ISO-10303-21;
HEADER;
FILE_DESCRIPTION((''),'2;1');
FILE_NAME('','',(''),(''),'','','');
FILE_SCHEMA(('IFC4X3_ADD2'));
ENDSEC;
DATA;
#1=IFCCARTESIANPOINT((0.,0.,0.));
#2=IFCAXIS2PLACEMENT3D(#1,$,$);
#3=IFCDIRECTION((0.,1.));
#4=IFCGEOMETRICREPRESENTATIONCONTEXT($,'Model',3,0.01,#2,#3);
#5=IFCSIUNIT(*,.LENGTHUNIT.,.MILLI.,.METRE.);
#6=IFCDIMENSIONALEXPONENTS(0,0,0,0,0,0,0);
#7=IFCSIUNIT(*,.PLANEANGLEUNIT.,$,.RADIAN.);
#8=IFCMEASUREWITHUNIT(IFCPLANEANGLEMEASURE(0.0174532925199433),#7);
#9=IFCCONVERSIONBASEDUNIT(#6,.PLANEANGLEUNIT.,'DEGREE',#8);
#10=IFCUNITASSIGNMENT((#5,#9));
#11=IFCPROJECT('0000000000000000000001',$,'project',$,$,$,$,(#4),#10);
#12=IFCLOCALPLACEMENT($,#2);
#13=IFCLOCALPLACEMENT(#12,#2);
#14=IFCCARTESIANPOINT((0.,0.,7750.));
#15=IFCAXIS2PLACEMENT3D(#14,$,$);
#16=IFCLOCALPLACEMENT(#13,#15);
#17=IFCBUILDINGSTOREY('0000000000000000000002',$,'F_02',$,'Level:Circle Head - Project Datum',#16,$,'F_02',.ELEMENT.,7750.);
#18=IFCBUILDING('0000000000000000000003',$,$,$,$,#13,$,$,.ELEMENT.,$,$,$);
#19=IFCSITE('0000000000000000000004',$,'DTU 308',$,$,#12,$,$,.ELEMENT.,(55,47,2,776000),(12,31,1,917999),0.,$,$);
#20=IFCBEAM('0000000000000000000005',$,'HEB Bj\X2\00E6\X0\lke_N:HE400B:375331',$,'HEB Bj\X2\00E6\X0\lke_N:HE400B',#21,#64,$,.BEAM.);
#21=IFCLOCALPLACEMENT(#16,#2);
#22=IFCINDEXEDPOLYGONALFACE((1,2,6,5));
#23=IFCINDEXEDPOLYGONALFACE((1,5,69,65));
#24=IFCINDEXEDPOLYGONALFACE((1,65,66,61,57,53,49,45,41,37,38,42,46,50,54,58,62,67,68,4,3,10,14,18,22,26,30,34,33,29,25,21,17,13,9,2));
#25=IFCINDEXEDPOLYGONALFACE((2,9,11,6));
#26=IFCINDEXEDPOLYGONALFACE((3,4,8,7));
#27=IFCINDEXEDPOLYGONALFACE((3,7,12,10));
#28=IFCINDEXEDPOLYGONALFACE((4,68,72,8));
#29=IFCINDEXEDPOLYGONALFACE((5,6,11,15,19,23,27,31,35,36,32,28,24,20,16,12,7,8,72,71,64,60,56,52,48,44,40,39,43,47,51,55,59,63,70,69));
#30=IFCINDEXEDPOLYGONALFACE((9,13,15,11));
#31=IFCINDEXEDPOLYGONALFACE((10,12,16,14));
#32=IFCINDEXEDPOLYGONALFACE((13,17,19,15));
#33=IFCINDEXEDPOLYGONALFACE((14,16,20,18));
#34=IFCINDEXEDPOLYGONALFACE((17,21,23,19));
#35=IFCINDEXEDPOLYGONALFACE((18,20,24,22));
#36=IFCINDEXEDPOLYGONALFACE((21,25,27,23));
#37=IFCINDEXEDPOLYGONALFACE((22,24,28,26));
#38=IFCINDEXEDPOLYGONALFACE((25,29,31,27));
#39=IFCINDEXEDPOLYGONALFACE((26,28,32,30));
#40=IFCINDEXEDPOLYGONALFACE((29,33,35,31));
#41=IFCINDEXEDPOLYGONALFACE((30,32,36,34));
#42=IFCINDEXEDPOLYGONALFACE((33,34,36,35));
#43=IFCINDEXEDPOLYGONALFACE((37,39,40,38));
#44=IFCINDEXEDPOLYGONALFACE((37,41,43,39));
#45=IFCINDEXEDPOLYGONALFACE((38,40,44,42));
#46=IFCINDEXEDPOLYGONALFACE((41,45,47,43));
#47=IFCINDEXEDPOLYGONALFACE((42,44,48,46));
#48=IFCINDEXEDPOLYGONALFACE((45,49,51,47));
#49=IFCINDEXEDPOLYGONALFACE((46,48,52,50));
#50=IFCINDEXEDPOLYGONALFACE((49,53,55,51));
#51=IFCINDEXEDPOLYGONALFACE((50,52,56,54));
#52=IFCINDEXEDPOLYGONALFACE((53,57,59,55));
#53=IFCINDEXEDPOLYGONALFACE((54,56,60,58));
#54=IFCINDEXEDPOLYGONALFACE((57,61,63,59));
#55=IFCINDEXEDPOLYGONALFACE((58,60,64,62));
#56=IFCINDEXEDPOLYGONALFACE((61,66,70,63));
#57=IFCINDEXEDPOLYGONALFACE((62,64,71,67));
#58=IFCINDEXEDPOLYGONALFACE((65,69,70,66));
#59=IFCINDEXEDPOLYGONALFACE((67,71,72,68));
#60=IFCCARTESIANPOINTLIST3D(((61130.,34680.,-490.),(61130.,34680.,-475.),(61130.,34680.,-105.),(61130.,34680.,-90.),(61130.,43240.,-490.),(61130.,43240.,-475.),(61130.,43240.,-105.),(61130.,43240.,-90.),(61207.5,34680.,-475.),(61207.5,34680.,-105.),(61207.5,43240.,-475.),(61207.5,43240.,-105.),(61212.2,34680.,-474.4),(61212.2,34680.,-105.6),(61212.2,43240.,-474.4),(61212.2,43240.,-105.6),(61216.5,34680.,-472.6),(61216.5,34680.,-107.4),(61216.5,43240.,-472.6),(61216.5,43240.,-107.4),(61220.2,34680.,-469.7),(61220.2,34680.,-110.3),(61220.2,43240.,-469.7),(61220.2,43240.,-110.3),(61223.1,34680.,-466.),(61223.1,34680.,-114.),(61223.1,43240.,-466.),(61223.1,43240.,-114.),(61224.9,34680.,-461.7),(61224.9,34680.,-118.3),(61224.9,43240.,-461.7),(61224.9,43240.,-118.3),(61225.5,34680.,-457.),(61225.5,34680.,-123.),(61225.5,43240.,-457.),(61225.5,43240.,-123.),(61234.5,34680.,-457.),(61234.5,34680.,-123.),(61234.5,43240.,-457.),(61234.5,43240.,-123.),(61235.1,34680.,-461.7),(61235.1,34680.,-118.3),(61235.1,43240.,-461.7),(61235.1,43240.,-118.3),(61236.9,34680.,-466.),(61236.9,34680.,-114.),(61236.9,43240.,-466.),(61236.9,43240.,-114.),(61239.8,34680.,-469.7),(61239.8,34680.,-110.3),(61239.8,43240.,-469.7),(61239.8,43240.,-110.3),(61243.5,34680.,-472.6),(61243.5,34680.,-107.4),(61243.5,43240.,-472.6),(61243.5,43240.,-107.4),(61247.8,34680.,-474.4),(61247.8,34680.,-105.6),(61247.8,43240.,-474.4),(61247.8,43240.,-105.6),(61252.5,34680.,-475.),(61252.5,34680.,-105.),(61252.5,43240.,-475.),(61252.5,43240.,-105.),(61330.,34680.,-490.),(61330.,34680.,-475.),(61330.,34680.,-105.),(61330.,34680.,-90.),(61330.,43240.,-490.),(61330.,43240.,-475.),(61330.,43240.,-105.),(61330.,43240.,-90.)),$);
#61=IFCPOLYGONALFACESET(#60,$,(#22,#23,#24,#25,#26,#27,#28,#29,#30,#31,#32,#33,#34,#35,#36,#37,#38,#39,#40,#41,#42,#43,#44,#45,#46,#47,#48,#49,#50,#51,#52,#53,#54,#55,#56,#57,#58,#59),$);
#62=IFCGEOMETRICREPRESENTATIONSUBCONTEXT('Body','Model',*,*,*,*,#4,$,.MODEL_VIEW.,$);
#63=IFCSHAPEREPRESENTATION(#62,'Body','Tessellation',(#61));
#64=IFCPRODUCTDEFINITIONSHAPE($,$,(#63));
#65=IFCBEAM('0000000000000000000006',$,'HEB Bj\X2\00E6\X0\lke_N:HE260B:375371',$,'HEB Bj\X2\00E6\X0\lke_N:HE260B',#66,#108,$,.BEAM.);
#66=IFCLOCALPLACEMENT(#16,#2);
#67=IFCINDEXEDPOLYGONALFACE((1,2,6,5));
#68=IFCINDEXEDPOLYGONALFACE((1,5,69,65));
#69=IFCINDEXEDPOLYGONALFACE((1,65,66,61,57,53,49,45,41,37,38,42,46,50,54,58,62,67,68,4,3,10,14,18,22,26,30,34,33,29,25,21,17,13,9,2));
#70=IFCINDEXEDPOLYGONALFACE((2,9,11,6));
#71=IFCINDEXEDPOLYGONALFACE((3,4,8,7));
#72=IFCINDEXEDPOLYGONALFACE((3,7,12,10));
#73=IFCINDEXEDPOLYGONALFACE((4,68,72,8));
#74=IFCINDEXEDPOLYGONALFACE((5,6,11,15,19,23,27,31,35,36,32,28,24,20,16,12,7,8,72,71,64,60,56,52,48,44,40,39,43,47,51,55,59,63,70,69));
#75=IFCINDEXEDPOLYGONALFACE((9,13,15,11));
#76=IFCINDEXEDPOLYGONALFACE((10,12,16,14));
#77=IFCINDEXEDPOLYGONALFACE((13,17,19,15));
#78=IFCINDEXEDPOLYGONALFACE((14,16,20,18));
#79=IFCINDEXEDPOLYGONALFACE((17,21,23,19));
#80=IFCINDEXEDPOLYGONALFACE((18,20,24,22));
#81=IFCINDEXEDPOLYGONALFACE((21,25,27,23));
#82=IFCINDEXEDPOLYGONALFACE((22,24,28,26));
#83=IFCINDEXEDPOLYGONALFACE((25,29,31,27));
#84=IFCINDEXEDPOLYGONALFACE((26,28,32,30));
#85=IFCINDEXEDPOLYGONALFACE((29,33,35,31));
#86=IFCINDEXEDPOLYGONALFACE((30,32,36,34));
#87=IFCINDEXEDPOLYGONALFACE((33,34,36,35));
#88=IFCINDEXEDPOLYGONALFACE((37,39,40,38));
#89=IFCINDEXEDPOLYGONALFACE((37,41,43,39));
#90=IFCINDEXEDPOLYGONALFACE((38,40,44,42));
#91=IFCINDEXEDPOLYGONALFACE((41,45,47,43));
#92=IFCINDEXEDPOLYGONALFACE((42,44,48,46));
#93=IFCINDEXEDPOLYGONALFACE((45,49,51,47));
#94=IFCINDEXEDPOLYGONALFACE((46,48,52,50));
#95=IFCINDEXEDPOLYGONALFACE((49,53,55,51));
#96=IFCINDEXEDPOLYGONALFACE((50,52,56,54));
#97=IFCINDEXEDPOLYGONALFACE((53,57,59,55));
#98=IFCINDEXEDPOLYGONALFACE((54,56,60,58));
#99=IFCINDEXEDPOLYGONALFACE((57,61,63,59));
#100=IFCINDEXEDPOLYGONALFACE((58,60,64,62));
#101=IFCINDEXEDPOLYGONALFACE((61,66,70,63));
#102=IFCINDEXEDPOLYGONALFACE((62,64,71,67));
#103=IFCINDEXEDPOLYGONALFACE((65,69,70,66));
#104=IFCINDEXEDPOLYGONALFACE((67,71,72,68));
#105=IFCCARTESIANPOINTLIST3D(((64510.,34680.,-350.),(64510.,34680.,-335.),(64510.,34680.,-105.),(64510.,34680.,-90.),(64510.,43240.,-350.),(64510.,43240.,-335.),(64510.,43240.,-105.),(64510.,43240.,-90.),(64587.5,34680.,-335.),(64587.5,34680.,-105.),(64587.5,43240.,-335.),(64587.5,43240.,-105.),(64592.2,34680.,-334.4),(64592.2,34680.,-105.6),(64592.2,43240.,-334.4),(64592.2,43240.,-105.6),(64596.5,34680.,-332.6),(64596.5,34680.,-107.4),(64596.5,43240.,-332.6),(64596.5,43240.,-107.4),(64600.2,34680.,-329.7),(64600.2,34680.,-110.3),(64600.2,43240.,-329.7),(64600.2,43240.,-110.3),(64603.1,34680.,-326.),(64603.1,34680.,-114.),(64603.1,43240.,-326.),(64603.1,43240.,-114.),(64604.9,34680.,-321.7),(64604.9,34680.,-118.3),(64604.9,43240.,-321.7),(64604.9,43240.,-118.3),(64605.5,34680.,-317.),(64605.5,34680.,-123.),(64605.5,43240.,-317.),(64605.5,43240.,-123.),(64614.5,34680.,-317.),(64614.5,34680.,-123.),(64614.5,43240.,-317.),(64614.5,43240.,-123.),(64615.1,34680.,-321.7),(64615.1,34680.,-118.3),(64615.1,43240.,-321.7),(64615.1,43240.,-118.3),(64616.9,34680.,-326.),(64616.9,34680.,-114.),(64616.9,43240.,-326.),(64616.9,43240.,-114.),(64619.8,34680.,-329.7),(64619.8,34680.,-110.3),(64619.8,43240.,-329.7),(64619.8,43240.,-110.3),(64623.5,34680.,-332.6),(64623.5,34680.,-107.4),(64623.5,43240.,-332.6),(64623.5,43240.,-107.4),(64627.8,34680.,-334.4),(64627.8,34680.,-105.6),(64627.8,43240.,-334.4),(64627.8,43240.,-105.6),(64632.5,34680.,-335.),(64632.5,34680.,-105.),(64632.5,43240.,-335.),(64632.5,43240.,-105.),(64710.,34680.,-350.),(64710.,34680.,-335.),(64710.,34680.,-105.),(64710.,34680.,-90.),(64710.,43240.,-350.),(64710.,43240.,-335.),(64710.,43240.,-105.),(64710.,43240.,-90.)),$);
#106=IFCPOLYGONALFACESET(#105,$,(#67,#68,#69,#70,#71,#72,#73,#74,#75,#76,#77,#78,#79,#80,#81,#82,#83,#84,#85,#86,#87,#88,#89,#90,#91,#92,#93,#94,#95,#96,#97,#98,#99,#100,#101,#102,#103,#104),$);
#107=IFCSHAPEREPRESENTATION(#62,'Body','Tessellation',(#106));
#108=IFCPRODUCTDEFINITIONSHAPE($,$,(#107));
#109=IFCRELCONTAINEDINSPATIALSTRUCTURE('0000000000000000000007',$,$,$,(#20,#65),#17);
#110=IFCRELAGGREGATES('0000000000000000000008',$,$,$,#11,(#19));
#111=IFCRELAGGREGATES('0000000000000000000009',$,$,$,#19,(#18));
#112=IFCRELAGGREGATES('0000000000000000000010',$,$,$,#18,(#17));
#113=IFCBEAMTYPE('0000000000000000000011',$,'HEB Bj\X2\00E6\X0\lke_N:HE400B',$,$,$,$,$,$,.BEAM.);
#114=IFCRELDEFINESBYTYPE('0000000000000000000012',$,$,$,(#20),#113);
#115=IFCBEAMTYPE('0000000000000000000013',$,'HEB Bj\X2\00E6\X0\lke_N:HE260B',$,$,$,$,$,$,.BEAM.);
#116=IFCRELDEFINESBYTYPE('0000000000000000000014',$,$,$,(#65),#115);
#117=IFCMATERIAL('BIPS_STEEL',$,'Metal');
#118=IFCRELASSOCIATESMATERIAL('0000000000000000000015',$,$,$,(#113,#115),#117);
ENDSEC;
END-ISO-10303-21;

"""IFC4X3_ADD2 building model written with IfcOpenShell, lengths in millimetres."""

from ifc_helpers import new_model, entity, si_unit, converted_unit, direction, frame, frame_2d, origin, place, context, subcontext, project, spatial, polyline, circle_curve, parameter, trimmed, segment, composite_curve, i_section, outline, extrude, source, transform, mapped, material, material_profile, profile_set, type_object, element, save


model = new_model("IFC4X3_ADD2")

# Units and contexts
model_context = context("Model", 3, precision=0.01, world=origin(), true_north=direction((0.0, 1.0)))
body_context = subcontext(model_context, "Body", "Model", "MODEL_VIEW")
ifc_project = project(units=[si_unit("LENGTHUNIT", "METRE", prefix="MILLI"), converted_unit("PLANEANGLEUNIT", "DEGREE", entity("IfcPlaneAngleMeasure", 0.0174532925199433), si_unit("PLANEANGLEUNIT", "RADIAN"), dimensions=[0, 0, 0, 0, 0, 0, 0])], contexts=[model_context])

# Site, building, storey
site_placement = place(None, origin())
site = spatial("IfcSite", under=ifc_project, at=site_placement, Name="DTU 308", CompositionType="ELEMENT", RefLatitude=(55, 47, 2, 776000), RefLongitude=(12, 31, 1, 917999), RefElevation=0.0)
building_placement = place(site_placement, origin())
building = spatial("IfcBuilding", under=site, at=building_placement, CompositionType="ELEMENT")
storey_placement = place(building_placement, frame((0.0, 0.0, 7750.0)))
storey = spatial("IfcBuildingStorey", under=building, at=storey_placement, Name="F_02", ObjectType="Level:Circle Head - Project Datum", LongName="F_02", CompositionType="ELEMENT", Elevation=7750.0)

# Shared definitions
ifc_material = material(Name="BIPS_STEEL", Category="Metal")

# Beams
ifc_material_profile_1 = material_profile(ifc_material, outline(composite_curve([segment(polyline([(-100.0, -185.0), (-100.0, -200.0)]), True, "CONTINUOUS"), segment(polyline([(-100.0, -200.0), (100.0, -200.0)]), True, "CONTINUOUS"), segment(polyline([(100.0, -200.0), (100.0, -185.0)]), True, "CONTINUOUS"), segment(polyline([(100.0, -185.0), (22.5, -185.0)]), True, "CONTINUOUS"), segment(trimmed(circle_curve(frame_2d((22.5, -167.0), x_axis=(1.0, 0.0)), 18.0), [parameter(180.0)], [parameter(270.0)], True, "PARAMETER"), False, "CONTINUOUS"), segment(polyline([(4.5, -167.0), (4.5, 167.0)]), True, "CONTINUOUS"), segment(trimmed(circle_curve(frame_2d((22.5, 167.0), x_axis=(1.0, 0.0)), 18.0), [parameter(90.0)], [parameter(180.0)], True, "PARAMETER"), False, "CONTINUOUS"), segment(polyline([(22.5, 185.0), (100.0, 185.0)]), True, "CONTINUOUS"), segment(polyline([(100.0, 185.0), (100.0, 200.0)]), True, "CONTINUOUS"), segment(polyline([(100.0, 200.0), (-100.0, 200.0)]), True, "CONTINUOUS"), segment(polyline([(-100.0, 200.0), (-100.0, 185.0)]), True, "CONTINUOUS"), segment(polyline([(-100.0, 185.0), (-22.5, 185.0)]), True, "CONTINUOUS"), segment(trimmed(circle_curve(frame_2d((-22.5, 167.0), x_axis=(1.0, 0.0)), 18.0), [parameter(360.0)], [parameter(90.0)], True, "PARAMETER"), False, "CONTINUOUS"), segment(polyline([(-4.5, 167.0), (-4.5, -167.0)]), True, "CONTINUOUS"), segment(trimmed(circle_curve(frame_2d((-22.5, -167.0), x_axis=(1.0, 0.0)), 18.0), [parameter(270.0)], [parameter(360.0)], True, "PARAMETER"), False, "CONTINUOUS"), segment(polyline([(-22.5, -185.0), (-100.0, -185.0)]), True, "CONTINUOUS")], self_intersect=False)), Name="HE400B")
ifc_profile_set_1 = profile_set([ifc_material_profile_1], Name="HE400B")
beam_type_1 = type_object("IfcBeamType", Name="HEB Bjælke_N:HE400B", PredefinedType="BEAM", material=ifc_profile_set_1)
shared_shape_1 = source(origin(), body_context, "Body", "SweptSolid", [
    extrude(outline(composite_curve([segment(polyline([(-100.0, -185.0), (-100.0, -200.0)]), True, "CONTINUOUS"), segment(polyline([(-100.0, -200.0), (100.0, -200.0)]), True, "CONTINUOUS"), segment(polyline([(100.0, -200.0), (100.0, -185.0)]), True, "CONTINUOUS"), segment(polyline([(100.0, -185.0), (22.5, -185.0)]), True, "CONTINUOUS"), segment(trimmed(circle_curve(frame_2d((22.5, -167.0), x_axis=(1.0, 0.0)), 18.0), [parameter(180.0)], [parameter(270.0)], True, "PARAMETER"), False, "CONTINUOUS"), segment(polyline([(4.5, -167.0), (4.5, 167.0)]), True, "CONTINUOUS"), segment(trimmed(circle_curve(frame_2d((22.5, 167.0), x_axis=(1.0, 0.0)), 18.0), [parameter(90.0)], [parameter(180.0)], True, "PARAMETER"), False, "CONTINUOUS"), segment(polyline([(22.5, 185.0), (100.0, 185.0)]), True, "CONTINUOUS"), segment(polyline([(100.0, 185.0), (100.0, 200.0)]), True, "CONTINUOUS"), segment(polyline([(100.0, 200.0), (-100.0, 200.0)]), True, "CONTINUOUS"), segment(polyline([(-100.0, 200.0), (-100.0, 185.0)]), True, "CONTINUOUS"), segment(polyline([(-100.0, 185.0), (-22.5, 185.0)]), True, "CONTINUOUS"), segment(trimmed(circle_curve(frame_2d((-22.5, 167.0), x_axis=(1.0, 0.0)), 18.0), [parameter(360.0)], [parameter(90.0)], True, "PARAMETER"), False, "CONTINUOUS"), segment(polyline([(-4.5, 167.0), (-4.5, -167.0)]), True, "CONTINUOUS"), segment(trimmed(circle_curve(frame_2d((-22.5, -167.0), x_axis=(1.0, 0.0)), 18.0), [parameter(270.0)], [parameter(360.0)], True, "PARAMETER"), False, "CONTINUOUS"), segment(polyline([(-22.5, -185.0), (-100.0, -185.0)]), True, "CONTINUOUS")], self_intersect=False)), frame((-4280.0, 0.0, 0.0), z_axis=(-1.0, 0.0, 0.0), x_axis=(0.0, -1.0, 0.0)), (0.0, 0.0, -1.0), 8560.0),
])
for number, where, z_axis, x_axis, name in (
    (1, (61230.0, 38960.0, -290.0), (0.0, 0.0, 1.0), (0.0, -1.0, 0.0), "HEB Bjælke_N:HE400B:375331"),
):
    element("IfcBeam", number, at=place(storey_placement, frame(where, z_axis=z_axis, x_axis=x_axis)), inside=storey, type_object=beam_type_1, Name=name, ObjectType="HEB Bjælke_N:HE400B", PredefinedType="BEAM", context=body_context, shape_type="MappedRepresentation", body=[
        mapped(shared_shape_1, transform((0.0, 0.0, 0.0), scale=1.0)),
    ])
ifc_material_profile_2 = material_profile(ifc_material, i_section(OverallWidth=200.0, OverallDepth=260.0, WebThickness=9.0, FlangeThickness=15.0, FilletRadius=18.0, at=frame_2d((0.0, 0.0), x_axis=(1.0, 0.0))), Name="HE260B")
ifc_profile_set_2 = profile_set([ifc_material_profile_2], Name="HE260B")
beam_type_2 = type_object("IfcBeamType", Name="HEB Bjælke_N:HE260B", PredefinedType="BEAM", material=ifc_profile_set_2)
shared_shape_2 = source(origin(), body_context, "Body", "SweptSolid", [
    extrude(outline(composite_curve([segment(polyline([(-100.0, -115.0), (-100.0, -130.0)]), True, "CONTINUOUS"), segment(polyline([(-100.0, -130.0), (100.0, -130.0)]), True, "CONTINUOUS"), segment(polyline([(100.0, -130.0), (100.0, -115.0)]), True, "CONTINUOUS"), segment(polyline([(100.0, -115.0), (22.5, -115.0)]), True, "CONTINUOUS"), segment(trimmed(circle_curve(frame_2d((22.5, -97.0), x_axis=(1.0, 0.0)), 18.0), [parameter(180.0)], [parameter(270.0)], True, "PARAMETER"), False, "CONTINUOUS"), segment(polyline([(4.5, -97.0), (4.5, 97.0)]), True, "CONTINUOUS"), segment(trimmed(circle_curve(frame_2d((22.5, 97.0), x_axis=(1.0, 0.0)), 18.0), [parameter(90.0)], [parameter(180.0)], True, "PARAMETER"), False, "CONTINUOUS"), segment(polyline([(22.5, 115.0), (100.0, 115.0)]), True, "CONTINUOUS"), segment(polyline([(100.0, 115.0), (100.0, 130.0)]), True, "CONTINUOUS"), segment(polyline([(100.0, 130.0), (-100.0, 130.0)]), True, "CONTINUOUS"), segment(polyline([(-100.0, 130.0), (-100.0, 115.0)]), True, "CONTINUOUS"), segment(polyline([(-100.0, 115.0), (-22.5, 115.0)]), True, "CONTINUOUS"), segment(trimmed(circle_curve(frame_2d((-22.5, 97.0), x_axis=(1.0, 0.0)), 18.0), [parameter(360.0)], [parameter(90.0)], True, "PARAMETER"), False, "CONTINUOUS"), segment(polyline([(-4.5, 97.0), (-4.5, -97.0)]), True, "CONTINUOUS"), segment(trimmed(circle_curve(frame_2d((-22.5, -97.0), x_axis=(1.0, 0.0)), 18.0), [parameter(270.0)], [parameter(360.0)], True, "PARAMETER"), False, "CONTINUOUS"), segment(polyline([(-22.5, -115.0), (-100.0, -115.0)]), True, "CONTINUOUS")], self_intersect=False)), frame((-4280.0, 0.0, 0.0), z_axis=(-1.0, 0.0, 0.0), x_axis=(0.0, -1.0, 0.0)), (0.0, 0.0, -1.0), 8560.0),
])
beam_1_placement = place(storey_placement, frame((64610.0, 38960.0, -220.0), z_axis=(0.0, 0.0, 1.0), x_axis=(0.0, -1.0, 0.0)))
element("IfcBeam", 2, at=beam_1_placement, inside=storey, type_object=beam_type_2, Name="HEB Bjælke_N:HE260B:375371", ObjectType="HEB Bjælke_N:HE260B", PredefinedType="BEAM", context=body_context, shape_type="MappedRepresentation", body=[
    mapped(shared_shape_2, transform((0.0, 0.0, 0.0), scale=1.0)),
])

save(model, "model.ifc")
